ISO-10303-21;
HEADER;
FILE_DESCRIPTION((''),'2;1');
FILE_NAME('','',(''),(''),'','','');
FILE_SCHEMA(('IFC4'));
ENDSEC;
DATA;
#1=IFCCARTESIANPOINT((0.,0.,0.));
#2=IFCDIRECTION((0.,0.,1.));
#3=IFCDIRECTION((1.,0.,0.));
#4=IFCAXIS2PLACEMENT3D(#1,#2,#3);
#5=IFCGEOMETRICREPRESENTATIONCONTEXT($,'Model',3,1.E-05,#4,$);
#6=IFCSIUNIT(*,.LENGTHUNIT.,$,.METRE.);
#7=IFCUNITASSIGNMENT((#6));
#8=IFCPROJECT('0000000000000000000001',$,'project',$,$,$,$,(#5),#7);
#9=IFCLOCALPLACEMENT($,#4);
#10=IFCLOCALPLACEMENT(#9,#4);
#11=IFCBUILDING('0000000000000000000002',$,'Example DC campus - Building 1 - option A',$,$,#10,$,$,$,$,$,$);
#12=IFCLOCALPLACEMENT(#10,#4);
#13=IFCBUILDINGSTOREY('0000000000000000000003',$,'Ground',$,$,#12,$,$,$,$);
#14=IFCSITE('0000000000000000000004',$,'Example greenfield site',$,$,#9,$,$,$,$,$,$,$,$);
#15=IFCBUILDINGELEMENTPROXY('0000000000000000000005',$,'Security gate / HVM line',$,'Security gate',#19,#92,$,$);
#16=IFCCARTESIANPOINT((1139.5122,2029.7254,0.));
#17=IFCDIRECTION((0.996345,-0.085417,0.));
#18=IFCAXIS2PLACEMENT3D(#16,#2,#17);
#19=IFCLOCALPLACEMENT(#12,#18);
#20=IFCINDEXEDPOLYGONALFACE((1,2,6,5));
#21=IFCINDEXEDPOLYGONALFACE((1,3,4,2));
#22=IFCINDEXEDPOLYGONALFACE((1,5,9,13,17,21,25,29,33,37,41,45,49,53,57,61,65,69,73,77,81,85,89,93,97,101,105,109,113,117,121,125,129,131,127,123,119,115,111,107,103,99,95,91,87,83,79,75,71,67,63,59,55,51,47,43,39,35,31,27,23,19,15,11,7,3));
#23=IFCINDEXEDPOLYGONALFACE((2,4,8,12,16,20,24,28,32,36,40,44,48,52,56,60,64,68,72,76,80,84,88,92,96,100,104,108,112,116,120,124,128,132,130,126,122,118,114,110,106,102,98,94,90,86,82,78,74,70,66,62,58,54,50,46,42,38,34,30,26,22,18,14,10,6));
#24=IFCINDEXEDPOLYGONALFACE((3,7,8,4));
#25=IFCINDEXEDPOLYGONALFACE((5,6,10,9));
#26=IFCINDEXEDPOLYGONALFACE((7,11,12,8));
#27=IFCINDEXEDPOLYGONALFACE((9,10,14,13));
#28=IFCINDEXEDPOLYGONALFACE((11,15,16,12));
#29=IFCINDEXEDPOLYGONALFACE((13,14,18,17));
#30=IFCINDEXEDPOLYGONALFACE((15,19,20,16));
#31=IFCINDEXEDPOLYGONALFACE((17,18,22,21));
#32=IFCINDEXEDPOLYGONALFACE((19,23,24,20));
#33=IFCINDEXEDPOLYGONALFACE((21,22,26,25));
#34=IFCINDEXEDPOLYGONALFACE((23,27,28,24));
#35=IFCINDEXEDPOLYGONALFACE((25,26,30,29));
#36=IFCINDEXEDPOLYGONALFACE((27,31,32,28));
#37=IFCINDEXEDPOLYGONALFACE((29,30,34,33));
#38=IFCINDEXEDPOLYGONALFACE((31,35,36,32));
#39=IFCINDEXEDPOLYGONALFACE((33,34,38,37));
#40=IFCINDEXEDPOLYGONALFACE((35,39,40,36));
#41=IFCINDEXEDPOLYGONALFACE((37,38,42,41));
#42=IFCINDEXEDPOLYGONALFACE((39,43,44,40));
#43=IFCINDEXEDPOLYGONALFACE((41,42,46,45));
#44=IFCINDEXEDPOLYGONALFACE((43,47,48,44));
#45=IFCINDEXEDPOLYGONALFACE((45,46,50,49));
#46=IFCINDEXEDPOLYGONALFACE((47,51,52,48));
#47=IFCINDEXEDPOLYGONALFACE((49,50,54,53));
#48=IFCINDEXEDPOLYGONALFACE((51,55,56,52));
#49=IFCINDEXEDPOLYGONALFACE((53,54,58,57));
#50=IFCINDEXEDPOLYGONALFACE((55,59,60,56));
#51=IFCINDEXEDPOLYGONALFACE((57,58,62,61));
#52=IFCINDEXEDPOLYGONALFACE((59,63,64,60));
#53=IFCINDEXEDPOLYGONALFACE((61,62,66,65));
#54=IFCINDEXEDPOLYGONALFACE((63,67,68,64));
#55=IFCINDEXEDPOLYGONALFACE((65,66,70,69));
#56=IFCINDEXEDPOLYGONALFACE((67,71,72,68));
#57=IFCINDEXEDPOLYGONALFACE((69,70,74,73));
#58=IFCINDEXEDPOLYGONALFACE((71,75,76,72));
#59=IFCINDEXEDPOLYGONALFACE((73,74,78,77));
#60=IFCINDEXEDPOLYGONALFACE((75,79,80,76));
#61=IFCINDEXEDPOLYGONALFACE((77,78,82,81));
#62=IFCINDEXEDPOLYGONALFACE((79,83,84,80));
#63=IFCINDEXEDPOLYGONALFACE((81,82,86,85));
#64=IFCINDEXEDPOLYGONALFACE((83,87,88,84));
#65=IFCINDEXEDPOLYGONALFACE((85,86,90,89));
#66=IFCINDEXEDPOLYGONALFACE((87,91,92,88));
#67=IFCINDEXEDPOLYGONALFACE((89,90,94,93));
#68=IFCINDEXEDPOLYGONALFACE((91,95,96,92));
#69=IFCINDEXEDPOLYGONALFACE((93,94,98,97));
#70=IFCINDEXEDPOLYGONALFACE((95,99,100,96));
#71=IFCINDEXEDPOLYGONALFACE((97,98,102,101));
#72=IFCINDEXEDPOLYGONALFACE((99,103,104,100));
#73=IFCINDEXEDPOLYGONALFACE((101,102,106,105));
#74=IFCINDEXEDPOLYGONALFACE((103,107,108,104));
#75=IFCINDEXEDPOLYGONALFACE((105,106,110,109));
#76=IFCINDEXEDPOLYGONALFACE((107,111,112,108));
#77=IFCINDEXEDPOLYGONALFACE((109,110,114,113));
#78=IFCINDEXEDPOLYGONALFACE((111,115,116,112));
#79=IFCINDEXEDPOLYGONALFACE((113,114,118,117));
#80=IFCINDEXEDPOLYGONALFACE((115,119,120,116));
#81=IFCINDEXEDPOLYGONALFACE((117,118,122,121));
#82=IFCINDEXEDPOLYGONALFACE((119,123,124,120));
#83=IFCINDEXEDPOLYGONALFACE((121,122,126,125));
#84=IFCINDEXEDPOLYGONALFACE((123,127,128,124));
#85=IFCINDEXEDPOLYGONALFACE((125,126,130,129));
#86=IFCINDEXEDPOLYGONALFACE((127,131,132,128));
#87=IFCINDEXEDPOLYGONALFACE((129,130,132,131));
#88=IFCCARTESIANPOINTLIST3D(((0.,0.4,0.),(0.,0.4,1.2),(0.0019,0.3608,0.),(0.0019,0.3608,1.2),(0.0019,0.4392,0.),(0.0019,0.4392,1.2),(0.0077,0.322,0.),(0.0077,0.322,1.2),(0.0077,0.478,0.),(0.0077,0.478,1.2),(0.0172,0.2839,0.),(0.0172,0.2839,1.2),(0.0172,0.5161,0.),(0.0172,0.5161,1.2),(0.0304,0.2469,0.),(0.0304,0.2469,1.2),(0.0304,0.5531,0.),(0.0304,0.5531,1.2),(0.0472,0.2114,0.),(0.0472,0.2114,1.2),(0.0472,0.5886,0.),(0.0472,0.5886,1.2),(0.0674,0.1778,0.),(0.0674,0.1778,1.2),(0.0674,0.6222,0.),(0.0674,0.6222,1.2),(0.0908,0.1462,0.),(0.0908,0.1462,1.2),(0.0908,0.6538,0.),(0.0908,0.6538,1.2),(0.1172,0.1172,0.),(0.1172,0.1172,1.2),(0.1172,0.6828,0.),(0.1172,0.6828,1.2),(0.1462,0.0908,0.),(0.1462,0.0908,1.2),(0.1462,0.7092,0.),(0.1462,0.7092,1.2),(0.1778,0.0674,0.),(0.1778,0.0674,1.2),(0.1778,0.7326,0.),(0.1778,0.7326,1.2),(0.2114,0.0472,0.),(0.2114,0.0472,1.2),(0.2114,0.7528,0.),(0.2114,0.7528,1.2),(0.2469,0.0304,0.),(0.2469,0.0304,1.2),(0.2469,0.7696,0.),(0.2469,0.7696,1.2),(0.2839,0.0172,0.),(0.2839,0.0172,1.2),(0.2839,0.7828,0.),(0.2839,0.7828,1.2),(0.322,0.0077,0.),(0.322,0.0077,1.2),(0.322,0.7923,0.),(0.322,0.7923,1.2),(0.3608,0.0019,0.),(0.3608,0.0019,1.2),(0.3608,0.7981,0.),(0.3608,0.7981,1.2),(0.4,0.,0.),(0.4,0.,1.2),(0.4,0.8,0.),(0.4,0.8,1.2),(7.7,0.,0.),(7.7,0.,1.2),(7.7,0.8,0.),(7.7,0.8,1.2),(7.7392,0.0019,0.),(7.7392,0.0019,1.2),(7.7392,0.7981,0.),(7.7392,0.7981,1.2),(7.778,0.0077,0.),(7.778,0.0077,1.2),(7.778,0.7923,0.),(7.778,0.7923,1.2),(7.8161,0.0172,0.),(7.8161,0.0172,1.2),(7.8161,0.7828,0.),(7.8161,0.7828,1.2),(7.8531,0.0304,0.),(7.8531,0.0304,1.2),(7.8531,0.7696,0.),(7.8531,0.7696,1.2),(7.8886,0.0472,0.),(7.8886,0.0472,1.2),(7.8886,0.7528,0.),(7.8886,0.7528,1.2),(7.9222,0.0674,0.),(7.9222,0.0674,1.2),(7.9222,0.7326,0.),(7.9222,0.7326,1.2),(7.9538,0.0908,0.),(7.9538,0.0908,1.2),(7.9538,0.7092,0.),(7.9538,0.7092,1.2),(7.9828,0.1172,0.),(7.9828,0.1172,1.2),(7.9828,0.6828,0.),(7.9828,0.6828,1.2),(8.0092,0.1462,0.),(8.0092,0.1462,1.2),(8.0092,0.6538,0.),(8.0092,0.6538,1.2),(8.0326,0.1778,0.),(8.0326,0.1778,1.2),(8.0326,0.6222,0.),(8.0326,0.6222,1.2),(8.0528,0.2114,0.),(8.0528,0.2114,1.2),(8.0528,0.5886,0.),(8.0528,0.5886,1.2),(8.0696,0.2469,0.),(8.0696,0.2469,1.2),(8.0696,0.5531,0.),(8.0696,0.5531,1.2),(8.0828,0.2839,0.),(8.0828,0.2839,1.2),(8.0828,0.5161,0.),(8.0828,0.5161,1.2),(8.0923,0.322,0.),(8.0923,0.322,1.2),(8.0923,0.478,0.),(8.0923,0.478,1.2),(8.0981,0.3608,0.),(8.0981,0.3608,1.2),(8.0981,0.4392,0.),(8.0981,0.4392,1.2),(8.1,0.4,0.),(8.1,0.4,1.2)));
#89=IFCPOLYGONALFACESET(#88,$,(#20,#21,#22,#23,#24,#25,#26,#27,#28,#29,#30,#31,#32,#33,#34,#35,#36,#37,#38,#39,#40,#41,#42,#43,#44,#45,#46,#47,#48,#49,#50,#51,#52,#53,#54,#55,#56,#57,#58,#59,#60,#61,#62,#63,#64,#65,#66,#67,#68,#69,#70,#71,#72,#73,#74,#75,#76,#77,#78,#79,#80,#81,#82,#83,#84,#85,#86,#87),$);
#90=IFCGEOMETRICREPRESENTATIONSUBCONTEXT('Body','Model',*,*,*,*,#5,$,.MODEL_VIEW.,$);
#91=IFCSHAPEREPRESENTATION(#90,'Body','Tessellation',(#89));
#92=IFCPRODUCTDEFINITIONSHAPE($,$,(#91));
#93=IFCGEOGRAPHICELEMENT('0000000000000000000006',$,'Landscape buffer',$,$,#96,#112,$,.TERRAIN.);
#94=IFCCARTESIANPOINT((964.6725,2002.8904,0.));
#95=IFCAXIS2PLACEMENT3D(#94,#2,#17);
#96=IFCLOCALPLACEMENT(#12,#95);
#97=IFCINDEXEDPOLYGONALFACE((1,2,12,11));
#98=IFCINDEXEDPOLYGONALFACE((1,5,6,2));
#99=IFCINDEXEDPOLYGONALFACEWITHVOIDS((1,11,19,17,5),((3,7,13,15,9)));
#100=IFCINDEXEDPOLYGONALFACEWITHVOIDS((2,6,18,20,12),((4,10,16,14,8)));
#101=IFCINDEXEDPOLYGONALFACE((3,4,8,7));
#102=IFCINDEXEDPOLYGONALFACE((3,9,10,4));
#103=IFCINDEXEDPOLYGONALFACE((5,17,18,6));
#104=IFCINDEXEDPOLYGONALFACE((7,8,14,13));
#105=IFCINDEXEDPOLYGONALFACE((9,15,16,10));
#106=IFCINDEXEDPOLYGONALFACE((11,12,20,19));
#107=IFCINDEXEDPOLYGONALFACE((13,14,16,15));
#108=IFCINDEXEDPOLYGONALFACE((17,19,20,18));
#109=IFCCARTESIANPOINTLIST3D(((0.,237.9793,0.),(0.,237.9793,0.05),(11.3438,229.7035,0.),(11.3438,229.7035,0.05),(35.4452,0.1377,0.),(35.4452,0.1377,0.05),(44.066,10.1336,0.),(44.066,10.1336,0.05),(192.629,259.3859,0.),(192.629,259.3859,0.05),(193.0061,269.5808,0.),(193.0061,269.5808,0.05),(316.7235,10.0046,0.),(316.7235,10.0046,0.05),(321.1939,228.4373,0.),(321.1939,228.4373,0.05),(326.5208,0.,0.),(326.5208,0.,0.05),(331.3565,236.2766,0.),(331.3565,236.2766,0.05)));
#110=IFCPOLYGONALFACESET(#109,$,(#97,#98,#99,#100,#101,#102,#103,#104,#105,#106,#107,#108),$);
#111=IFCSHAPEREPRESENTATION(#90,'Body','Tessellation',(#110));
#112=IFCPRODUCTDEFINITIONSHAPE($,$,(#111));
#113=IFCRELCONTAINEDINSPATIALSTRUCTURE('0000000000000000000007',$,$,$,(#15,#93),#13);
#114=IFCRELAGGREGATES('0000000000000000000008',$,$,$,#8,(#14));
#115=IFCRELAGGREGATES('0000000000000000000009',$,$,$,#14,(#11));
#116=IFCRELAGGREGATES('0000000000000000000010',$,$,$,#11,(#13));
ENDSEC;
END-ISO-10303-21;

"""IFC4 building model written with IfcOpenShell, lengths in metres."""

from ifc_helpers import new_model, si_unit, frame, origin_with_axes, place, context, subcontext, project, spatial, line, indexed_curve, outline, extrude, element, save


model = new_model("IFC4")

# Units and contexts
model_context = context("Model", 3, precision=1e-05, world=origin_with_axes())
body_context = subcontext(model_context, "Body", "Model", "MODEL_VIEW")
ifc_project = project(units=[si_unit("LENGTHUNIT", "METRE")], contexts=[model_context])

# Site, building, storey
site_placement = place(None, origin_with_axes())
site = spatial("IfcSite", under=ifc_project, at=site_placement, Name="Example greenfield site")
building_placement = place(site_placement, origin_with_axes())
building = spatial("IfcBuilding", under=site, at=building_placement, Name="Example DC campus - Building 1 - option A")
storey_placement = place(building_placement, origin_with_axes())
storey = spatial("IfcBuildingStorey", under=building, at=storey_placement, Name="Ground")

# Building element proxy
proxy_1_placement = place(storey_placement, frame((1139.5122, 2029.7254, 0.0), z_axis=(0.0, 0.0, 1.0), x_axis=(0.996345, -0.085417, 0.0)))
element("IfcBuildingElementProxy", 1, at=proxy_1_placement, inside=storey, Name="Security gate / HVM line", ObjectType="Security gate", context=body_context, shape_type="SweptSolid", body=[
    extrude(outline(indexed_curve([(0.4, 0.0), (0.3608, 0.0019), (0.322, 0.0077), (0.2839, 0.0172), (0.2469, 0.0304), (0.2114, 0.0472), (0.1778, 0.0674), (0.1462, 0.0908), (0.1172, 0.1172), (0.0908, 0.1462), (0.0674, 0.1778), (0.0472, 0.2114), (0.0304, 0.2469), (0.0172, 0.2839), (0.0077, 0.322), (0.0019, 0.3608), (0.0, 0.4), (0.0019, 0.4392), (0.0077, 0.478), (0.0172, 0.5161), (0.0304, 0.5531), (0.0472, 0.5886), (0.0674, 0.6222), (0.0908, 0.6538), (0.1172, 0.6828), (0.1462, 0.7092), (0.1778, 0.7326), (0.2114, 0.7528), (0.2469, 0.7696), (0.2839, 0.7828), (0.322, 0.7923), (0.3608, 0.7981), (0.4, 0.8), (7.7, 0.8), (7.7392, 0.7981), (7.778, 0.7923), (7.8161, 0.7828), (7.8531, 0.7696), (7.8886, 0.7528), (7.9222, 0.7326), (7.9538, 0.7092), (7.9828, 0.6828), (8.0092, 0.6538), (8.0326, 0.6222), (8.0528, 0.5886), (8.0696, 0.5531), (8.0828, 0.5161), (8.0923, 0.478), (8.0981, 0.4392), (8.1, 0.4), (8.0981, 0.3608), (8.0923, 0.322), (8.0828, 0.2839), (8.0696, 0.2469), (8.0528, 0.2114), (8.0326, 0.1778), (8.0092, 0.1462), (7.9828, 0.1172), (7.9538, 0.0908), (7.9222, 0.0674), (7.8886, 0.0472), (7.8531, 0.0304), (7.8161, 0.0172), (7.778, 0.0077), (7.7392, 0.0019), (7.7, 0.0)], segments=[line(1, 2, 3, 4, 5, 6, 7, 8, 9, 10, 11, 12, 13, 14, 15, 16, 17, 18, 19, 20, 21, 22, 23, 24, 25, 26, 27, 28, 29, 30, 31, 32, 33, 34, 35, 36, 37, 38, 39, 40, 41, 42, 43, 44, 45, 46, 47, 48, 49, 50, 51, 52, 53, 54, 55, 56, 57, 58, 59, 60, 61, 62, 63, 64, 65, 66, 1)])), origin_with_axes(), (0.0, 0.0, 1.0), 1.2),
])

# Geographic element
geographic_element_placement = place(storey_placement, frame((964.6725, 2002.8904, 0.0), z_axis=(0.0, 0.0, 1.0), x_axis=(0.996345, -0.085417, 0.0)))
element("IfcGeographicElement", 2, at=geographic_element_placement, inside=storey, Name="Landscape buffer", PredefinedType="TERRAIN", context=body_context, shape_type="SweptSolid", body=[
    extrude(outline(indexed_curve([(0.0, 237.9793), (193.0061, 269.5808), (331.3565, 236.2766), (326.5208, 0.0), (35.4452, 0.1377)], segments=[line(1, 2, 3, 4, 5, 1)]), holes=[indexed_curve([(316.7235, 10.0046), (321.1939, 228.4373), (192.629, 259.3859), (11.3438, 229.7035), (44.066, 10.1336)], segments=[line(1, 2, 3, 4, 5, 1)])]), origin_with_axes(), (0.0, 0.0, 1.0), 0.05),
])

save(model, "model.ifc")
